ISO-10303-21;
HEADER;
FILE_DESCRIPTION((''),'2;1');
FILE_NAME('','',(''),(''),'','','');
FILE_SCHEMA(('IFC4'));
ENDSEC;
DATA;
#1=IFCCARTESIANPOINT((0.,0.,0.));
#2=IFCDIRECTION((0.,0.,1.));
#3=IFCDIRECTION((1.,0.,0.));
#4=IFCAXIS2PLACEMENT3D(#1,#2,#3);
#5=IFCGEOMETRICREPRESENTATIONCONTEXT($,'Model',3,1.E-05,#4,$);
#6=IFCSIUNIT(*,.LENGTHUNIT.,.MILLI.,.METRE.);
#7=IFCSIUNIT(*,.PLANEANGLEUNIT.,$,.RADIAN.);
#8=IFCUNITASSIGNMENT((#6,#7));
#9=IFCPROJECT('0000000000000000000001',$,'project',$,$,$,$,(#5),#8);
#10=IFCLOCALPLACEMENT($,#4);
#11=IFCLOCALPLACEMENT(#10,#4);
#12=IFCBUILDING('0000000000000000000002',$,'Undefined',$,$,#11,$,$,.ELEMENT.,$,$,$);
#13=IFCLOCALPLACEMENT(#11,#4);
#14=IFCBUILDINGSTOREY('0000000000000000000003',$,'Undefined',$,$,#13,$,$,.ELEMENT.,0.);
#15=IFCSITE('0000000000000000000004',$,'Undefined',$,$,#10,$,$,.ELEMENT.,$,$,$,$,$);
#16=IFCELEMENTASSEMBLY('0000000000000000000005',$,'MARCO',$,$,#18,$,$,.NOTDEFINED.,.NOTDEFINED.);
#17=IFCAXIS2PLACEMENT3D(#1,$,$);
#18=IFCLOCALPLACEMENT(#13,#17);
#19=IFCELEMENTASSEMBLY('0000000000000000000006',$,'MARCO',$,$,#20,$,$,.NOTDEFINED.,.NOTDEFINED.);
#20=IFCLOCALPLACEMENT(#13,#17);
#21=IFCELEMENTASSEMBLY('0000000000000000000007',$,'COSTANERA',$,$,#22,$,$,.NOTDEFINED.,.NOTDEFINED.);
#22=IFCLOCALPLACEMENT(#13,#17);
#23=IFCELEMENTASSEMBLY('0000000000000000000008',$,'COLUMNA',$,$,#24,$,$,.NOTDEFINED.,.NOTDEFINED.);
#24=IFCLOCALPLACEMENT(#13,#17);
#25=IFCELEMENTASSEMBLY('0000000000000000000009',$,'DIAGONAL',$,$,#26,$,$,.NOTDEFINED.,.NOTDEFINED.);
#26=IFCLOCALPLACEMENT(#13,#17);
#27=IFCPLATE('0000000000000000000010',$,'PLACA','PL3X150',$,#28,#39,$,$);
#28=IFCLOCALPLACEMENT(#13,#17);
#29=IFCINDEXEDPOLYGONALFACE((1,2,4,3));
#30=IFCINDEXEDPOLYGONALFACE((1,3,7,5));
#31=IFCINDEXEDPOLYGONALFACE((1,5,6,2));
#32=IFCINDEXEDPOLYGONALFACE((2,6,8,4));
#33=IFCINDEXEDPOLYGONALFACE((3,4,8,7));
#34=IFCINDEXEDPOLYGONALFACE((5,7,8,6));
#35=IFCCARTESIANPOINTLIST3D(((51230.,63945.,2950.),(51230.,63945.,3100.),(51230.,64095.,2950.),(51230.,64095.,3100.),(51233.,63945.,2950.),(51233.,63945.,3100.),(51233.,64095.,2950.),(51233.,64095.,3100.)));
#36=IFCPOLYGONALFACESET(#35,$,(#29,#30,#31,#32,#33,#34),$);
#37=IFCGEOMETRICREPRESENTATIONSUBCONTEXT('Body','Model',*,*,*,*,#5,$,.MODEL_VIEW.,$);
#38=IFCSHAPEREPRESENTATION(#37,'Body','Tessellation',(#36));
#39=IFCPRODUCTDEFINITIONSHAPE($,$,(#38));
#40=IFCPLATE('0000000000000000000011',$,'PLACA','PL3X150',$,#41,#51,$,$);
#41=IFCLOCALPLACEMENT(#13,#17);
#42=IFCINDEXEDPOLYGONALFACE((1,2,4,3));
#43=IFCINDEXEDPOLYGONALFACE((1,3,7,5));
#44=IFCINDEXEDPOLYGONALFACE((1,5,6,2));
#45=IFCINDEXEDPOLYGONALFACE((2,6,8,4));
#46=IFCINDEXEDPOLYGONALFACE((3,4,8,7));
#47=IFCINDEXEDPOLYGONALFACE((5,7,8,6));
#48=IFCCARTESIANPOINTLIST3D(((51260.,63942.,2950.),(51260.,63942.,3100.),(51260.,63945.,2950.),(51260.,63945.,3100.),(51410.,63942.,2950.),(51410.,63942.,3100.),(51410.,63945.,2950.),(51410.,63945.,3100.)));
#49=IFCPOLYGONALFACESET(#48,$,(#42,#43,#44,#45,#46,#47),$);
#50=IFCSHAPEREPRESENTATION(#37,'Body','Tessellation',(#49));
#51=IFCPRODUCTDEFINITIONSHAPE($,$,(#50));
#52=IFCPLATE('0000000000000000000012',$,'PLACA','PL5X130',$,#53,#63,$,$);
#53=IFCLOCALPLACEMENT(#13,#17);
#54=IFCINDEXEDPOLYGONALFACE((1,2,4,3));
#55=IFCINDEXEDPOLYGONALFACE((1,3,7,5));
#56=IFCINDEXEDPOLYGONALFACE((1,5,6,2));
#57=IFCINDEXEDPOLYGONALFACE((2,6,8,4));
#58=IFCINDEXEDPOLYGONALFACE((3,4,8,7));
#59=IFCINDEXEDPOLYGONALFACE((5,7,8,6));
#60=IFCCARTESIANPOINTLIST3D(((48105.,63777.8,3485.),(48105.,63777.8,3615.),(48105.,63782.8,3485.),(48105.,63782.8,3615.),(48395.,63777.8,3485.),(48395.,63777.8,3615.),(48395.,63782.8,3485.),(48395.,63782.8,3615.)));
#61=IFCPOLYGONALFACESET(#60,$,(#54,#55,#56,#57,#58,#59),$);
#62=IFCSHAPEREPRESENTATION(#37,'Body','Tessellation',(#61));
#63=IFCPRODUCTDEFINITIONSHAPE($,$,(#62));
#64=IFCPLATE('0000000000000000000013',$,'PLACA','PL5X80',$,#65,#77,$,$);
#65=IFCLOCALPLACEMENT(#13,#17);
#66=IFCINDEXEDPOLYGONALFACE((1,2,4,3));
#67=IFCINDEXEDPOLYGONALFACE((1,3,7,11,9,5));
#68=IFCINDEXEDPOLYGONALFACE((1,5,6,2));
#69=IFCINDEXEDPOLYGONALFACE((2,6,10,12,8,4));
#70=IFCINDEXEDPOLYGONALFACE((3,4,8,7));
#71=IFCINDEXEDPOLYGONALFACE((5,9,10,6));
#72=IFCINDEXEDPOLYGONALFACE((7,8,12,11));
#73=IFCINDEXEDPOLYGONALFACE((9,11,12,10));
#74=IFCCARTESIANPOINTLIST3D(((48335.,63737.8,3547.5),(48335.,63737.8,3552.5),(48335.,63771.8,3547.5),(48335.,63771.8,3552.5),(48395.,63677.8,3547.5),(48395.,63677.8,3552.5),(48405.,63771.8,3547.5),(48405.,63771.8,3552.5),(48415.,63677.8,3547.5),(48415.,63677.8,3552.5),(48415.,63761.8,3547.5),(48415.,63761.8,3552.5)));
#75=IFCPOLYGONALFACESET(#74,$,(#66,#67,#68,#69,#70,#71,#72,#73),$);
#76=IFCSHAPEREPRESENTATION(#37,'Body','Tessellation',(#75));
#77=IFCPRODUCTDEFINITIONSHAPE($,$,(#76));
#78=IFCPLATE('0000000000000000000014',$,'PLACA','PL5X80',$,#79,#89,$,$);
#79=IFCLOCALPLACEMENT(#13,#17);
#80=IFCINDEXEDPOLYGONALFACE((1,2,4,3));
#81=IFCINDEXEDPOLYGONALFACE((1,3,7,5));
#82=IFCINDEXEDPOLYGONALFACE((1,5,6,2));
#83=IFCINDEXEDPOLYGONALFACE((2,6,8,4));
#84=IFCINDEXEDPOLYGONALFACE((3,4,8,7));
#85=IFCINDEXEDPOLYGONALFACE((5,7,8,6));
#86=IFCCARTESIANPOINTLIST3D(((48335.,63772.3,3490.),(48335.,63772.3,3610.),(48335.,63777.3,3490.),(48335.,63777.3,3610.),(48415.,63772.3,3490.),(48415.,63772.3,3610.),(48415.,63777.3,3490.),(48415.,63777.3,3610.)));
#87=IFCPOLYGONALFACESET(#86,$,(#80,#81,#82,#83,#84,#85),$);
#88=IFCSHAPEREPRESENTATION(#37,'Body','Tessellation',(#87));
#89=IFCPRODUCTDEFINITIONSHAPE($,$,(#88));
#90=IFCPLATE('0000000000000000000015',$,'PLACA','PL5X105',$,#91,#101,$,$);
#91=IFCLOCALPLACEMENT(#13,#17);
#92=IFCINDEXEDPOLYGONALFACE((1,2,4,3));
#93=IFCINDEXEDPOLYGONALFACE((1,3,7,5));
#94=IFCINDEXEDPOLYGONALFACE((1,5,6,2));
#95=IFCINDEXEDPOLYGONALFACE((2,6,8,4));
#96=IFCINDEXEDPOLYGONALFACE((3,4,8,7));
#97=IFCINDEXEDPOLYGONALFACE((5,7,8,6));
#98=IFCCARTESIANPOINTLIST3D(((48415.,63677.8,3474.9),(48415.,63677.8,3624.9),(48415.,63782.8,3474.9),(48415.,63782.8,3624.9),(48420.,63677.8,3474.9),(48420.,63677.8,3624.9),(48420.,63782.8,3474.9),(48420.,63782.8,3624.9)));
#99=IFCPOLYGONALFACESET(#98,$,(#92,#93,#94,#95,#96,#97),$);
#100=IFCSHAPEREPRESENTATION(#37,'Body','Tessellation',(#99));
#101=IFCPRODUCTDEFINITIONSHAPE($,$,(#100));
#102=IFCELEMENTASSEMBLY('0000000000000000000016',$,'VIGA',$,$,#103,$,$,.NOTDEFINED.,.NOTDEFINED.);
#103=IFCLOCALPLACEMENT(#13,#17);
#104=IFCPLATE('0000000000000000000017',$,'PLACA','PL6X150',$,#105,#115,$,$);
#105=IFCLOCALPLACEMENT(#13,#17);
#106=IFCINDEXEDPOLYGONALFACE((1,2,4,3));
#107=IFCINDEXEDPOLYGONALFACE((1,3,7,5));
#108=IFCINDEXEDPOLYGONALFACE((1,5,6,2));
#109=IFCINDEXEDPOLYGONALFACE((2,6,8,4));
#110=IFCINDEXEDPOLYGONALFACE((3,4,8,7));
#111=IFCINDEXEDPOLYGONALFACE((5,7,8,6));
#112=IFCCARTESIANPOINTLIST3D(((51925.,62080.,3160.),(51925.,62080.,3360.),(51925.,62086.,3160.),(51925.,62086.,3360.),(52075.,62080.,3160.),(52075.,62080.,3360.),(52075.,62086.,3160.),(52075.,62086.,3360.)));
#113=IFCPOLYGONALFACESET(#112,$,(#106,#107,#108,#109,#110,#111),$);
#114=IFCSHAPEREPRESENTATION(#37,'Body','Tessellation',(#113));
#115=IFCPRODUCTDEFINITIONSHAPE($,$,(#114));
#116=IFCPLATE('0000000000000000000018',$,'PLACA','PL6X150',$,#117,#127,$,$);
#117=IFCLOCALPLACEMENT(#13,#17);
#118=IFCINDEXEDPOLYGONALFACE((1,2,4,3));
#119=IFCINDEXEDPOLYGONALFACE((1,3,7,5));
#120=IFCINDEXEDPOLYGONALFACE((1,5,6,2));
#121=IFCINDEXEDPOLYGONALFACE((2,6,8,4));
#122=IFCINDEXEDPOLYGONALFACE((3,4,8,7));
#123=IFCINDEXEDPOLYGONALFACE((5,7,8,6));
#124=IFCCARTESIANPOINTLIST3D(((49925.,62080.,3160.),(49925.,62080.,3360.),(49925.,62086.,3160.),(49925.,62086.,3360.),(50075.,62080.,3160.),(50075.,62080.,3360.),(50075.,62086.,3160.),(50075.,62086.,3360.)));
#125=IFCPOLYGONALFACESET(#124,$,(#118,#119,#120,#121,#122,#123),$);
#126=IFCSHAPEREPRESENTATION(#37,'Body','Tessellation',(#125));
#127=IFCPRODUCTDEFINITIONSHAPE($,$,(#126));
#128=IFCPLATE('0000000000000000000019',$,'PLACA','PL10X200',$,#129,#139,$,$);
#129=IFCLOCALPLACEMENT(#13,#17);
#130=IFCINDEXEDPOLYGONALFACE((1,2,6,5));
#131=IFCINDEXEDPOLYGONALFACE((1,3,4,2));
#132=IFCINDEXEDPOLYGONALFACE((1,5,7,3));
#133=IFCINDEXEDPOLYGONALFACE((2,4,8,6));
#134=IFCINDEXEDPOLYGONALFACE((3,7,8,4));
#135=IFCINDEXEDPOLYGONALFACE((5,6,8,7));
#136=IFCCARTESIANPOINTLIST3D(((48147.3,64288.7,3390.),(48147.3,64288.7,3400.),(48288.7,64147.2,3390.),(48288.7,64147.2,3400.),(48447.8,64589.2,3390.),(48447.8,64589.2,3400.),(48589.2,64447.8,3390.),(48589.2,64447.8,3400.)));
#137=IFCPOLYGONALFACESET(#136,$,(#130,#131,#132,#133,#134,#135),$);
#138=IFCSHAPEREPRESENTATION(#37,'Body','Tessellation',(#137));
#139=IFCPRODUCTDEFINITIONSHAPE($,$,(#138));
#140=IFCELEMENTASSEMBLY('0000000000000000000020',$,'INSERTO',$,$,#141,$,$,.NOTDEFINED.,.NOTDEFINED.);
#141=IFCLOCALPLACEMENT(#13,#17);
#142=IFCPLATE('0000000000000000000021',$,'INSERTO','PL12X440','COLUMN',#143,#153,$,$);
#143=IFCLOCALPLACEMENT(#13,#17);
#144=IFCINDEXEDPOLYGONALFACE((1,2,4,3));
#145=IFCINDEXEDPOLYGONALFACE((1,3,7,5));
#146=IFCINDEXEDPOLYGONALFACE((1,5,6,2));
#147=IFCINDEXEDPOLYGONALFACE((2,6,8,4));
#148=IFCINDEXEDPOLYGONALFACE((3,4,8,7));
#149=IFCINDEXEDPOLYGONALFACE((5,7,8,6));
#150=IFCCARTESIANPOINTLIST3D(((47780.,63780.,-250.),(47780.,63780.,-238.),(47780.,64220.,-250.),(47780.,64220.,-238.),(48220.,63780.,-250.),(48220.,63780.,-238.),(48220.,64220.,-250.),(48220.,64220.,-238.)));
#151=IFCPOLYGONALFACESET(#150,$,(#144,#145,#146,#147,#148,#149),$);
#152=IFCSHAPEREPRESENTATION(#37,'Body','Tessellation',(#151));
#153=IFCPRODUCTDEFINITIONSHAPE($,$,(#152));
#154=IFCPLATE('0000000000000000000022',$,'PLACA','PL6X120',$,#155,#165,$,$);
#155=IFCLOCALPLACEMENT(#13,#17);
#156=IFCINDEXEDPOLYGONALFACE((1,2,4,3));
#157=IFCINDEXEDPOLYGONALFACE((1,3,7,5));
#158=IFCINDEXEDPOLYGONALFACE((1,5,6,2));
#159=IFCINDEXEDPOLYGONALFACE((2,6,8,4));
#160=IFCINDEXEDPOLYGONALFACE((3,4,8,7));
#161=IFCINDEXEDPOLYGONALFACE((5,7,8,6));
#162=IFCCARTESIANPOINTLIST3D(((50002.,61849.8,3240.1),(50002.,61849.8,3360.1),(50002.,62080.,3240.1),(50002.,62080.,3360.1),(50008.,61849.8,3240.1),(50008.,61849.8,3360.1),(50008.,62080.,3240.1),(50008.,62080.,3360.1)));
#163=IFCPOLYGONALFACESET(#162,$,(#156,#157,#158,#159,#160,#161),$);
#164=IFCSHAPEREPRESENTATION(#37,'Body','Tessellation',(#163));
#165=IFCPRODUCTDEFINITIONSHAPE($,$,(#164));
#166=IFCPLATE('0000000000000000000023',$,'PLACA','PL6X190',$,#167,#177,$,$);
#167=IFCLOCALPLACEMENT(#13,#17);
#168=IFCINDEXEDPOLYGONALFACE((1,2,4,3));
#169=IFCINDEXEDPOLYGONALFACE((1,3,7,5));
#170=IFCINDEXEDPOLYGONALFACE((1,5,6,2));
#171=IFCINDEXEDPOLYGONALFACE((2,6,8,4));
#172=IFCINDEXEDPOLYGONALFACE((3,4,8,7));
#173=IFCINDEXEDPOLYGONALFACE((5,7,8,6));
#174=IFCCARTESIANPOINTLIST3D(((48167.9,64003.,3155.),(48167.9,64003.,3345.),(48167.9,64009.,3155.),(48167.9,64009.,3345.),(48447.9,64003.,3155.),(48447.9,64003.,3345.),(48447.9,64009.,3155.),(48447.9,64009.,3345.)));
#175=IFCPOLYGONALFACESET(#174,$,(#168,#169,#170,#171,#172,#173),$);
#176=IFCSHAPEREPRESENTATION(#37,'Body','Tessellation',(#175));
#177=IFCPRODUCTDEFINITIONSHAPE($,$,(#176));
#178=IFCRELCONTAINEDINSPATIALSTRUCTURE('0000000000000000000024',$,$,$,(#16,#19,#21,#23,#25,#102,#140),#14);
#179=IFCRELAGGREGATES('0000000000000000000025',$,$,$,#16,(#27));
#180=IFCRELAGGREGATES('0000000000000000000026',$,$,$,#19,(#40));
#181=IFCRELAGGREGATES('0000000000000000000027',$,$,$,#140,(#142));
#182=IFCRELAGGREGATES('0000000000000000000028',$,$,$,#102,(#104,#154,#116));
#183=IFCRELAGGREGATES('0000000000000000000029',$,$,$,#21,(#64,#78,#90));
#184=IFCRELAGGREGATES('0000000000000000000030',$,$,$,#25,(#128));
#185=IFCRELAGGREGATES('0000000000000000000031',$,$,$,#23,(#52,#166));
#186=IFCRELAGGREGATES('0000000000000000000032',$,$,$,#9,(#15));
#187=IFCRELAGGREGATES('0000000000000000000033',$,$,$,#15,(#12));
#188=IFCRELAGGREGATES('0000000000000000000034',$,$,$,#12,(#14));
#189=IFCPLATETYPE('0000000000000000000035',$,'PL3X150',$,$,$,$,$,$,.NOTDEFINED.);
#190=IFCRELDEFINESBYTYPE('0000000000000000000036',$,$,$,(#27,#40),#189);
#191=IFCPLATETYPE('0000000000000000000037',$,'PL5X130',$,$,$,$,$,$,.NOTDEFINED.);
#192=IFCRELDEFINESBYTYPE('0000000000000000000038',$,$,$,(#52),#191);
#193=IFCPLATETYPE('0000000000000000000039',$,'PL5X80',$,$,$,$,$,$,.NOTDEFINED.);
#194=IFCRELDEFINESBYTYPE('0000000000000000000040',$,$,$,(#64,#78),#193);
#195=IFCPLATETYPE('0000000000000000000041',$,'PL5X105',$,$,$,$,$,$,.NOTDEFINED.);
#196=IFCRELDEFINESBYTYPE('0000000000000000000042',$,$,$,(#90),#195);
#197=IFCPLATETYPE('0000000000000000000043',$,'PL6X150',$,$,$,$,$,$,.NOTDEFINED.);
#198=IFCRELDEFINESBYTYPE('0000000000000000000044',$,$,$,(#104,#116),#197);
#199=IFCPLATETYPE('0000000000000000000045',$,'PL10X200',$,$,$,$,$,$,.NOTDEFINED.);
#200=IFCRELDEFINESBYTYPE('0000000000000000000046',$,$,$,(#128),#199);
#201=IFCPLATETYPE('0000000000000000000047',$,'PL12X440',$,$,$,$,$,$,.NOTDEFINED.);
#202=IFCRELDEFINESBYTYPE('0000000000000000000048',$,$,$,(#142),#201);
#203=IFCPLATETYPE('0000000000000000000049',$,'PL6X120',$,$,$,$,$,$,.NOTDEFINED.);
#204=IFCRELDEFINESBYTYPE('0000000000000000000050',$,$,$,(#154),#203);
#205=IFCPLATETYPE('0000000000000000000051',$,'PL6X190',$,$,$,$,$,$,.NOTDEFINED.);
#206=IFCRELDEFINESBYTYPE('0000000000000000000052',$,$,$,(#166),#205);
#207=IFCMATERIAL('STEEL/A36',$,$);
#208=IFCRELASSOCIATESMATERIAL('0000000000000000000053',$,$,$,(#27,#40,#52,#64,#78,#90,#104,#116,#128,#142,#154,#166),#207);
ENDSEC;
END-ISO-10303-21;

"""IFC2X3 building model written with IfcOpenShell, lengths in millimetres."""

from ifc_helpers import new_model, si_unit, frame, origin_with_axes, place, context, subcontext, project, spatial, polyline, outline, extrude, material, type_object, element, aggregate, save


model = new_model("IFC2X3")

# Units and contexts
model_context = context("Model", 3, precision=1e-05, world=origin_with_axes())
body_context = subcontext(model_context, "Body", "Model", "MODEL_VIEW")
ifc_project = project(units=[si_unit("LENGTHUNIT", "METRE", prefix="MILLI"), si_unit("PLANEANGLEUNIT", "RADIAN")], contexts=[model_context])

# Site, building, storey
site_placement = place(None, origin_with_axes())
site = spatial("IfcSite", under=ifc_project, at=site_placement, Name="Undefined", CompositionType="ELEMENT")
building_placement = place(site_placement, origin_with_axes())
building = spatial("IfcBuilding", under=site, at=building_placement, Name="Undefined", CompositionType="ELEMENT")
storey_placement = place(building_placement, origin_with_axes())
storey = spatial("IfcBuildingStorey", under=building, at=storey_placement, Name="Undefined", CompositionType="ELEMENT", Elevation=0.0)

# Element assembly
assembly_1_placement = place(storey_placement, origin_with_axes())
assembly_1 = element("IfcElementAssembly", 1, at=assembly_1_placement, inside=storey, Name="MARCO", AssemblyPlace="NOTDEFINED", PredefinedType="NOTDEFINED")
ifc_material_1 = material(Name="STEEL/A36")

# Element assemblies
assembly_2_placement = place(storey_placement, origin_with_axes())
assembly_2 = element("IfcElementAssembly", 2, at=assembly_2_placement, inside=storey, Name="MARCO", AssemblyPlace="NOTDEFINED", PredefinedType="NOTDEFINED")
assembly_3_placement = place(storey_placement, origin_with_axes())
assembly_3 = element("IfcElementAssembly", 3, at=assembly_3_placement, inside=storey, Name="COSTANERA", AssemblyPlace="NOTDEFINED", PredefinedType="NOTDEFINED")
assembly_4_placement = place(storey_placement, origin_with_axes())
assembly_4 = element("IfcElementAssembly", 4, at=assembly_4_placement, inside=storey, Name="COLUMNA", AssemblyPlace="NOTDEFINED", PredefinedType="NOTDEFINED")

# Element assembly
assembly_5_placement = place(storey_placement, origin_with_axes())
assembly_5 = element("IfcElementAssembly", 5, at=assembly_5_placement, inside=storey, Name="DIAGONAL", AssemblyPlace="NOTDEFINED", PredefinedType="NOTDEFINED")

# Plates
plate_type_1 = type_object("IfcPlateType", Name="PL3X150", PredefinedType="NOTDEFINED")
plate_1_placement = place(assembly_1_placement, frame((51231.5, 64095.0, 2950.0), z_axis=(-1.0, 0.0, 0.0), x_axis=(0.0, -1.0, 0.0)))
plate_1 = element("IfcPlate", 6, at=plate_1_placement, type_object=plate_type_1, material=ifc_material_1, Name="PLACA", Description="PL3X150", context=body_context, shape_type="SweptSolid", body=[
    extrude(outline(polyline([(0.0, 0.0), (150.0, 0.0), (150.0, 150.0), (0.0, 150.0), (0.0, 0.0)])), frame((0.0, 0.0, -1.5), z_axis=(0.0, 0.0, 1.0), x_axis=(1.0, 0.0, 0.0)), (0.0, 0.0, 1.0), 3.0),
])
aggregate(assembly_1, [plate_1])
plate_2_placement = place(assembly_2_placement, frame((51410.0, 63943.5, 2950.0), z_axis=(0.0, 1.0, 0.0), x_axis=(-1.0, 0.0, 0.0)))
plate_2 = element("IfcPlate", 7, at=plate_2_placement, type_object=plate_type_1, material=ifc_material_1, Name="PLACA", Description="PL3X150", context=body_context, shape_type="SweptSolid", body=[
    extrude(outline(polyline([(0.0, 0.0), (150.0, 0.0), (150.0, 150.0), (0.0, 150.0), (0.0, 0.0)])), frame((0.0, 0.0, -1.5), z_axis=(0.0, 0.0, 1.0), x_axis=(1.0, 0.0, 0.0)), (0.0, 0.0, 1.0), 3.0),
])
aggregate(assembly_2, [plate_2])
plate_type_2 = type_object("IfcPlateType", Name="PL5X130", PredefinedType="NOTDEFINED")
plate_3_placement = place(assembly_4_placement, frame((48395.0, 63780.3, 3615.0), z_axis=(0.0, -1.0, 0.0), x_axis=(-1.0, 0.0, 0.0)))
plate_3 = element("IfcPlate", 8, at=plate_3_placement, type_object=plate_type_2, material=ifc_material_1, Name="PLACA", Description="PL5X130", context=body_context, shape_type="SweptSolid", body=[
    extrude(outline(polyline([(0.0, 0.0), (290.0, 0.0), (290.0, 130.0), (0.0, 130.0), (0.0, 0.0)])), frame((0.0, 0.0, -2.5), z_axis=(0.0, 0.0, 1.0), x_axis=(1.0, 0.0, 0.0)), (0.0, 0.0, 1.0), 5.0),
])
plate_type_3 = type_object("IfcPlateType", Name="PL5X80", PredefinedType="NOTDEFINED")
plate_4_placement = place(assembly_3_placement, frame((48335.0, 63771.8, 3550.0), z_axis=(0.0, 0.0, -1.0), x_axis=(1.0, 0.0, 0.0)))
plate_4 = element("IfcPlate", 9, at=plate_4_placement, type_object=plate_type_3, material=ifc_material_1, Name="PLACA", Description="PL5X80", context=body_context, shape_type="SweptSolid", body=[
    extrude(outline(polyline([(0.0, 0.0), (70.0, 0.0), (80.0, 10.0), (80.0, 94.0), (60.0, 94.0), (0.0, 34.0), (0.0, 0.0)])), frame((0.0, 0.0, -2.5), z_axis=(0.0, 0.0, 1.0), x_axis=(1.0, 0.0, 0.0)), (0.0, 0.0, 1.0), 5.0),
])
plate_5_placement = place(assembly_3_placement, frame((48335.0, 63774.8, 3610.0), z_axis=(0.0, 1.0, 0.0), x_axis=(1.0, 0.0, 0.0)))
plate_5 = element("IfcPlate", 10, at=plate_5_placement, type_object=plate_type_3, material=ifc_material_1, Name="PLACA", Description="PL5X80", context=body_context, shape_type="SweptSolid", body=[
    extrude(outline(polyline([(0.0, 0.0), (80.0, 0.0), (80.0, 120.0), (0.0, 120.0), (0.0, 0.0)])), frame((0.0, 0.0, -2.5), z_axis=(0.0, 0.0, 1.0), x_axis=(1.0, 0.0, 0.0)), (0.0, 0.0, 1.0), 5.0),
])
plate_type_4 = type_object("IfcPlateType", Name="PL5X105", PredefinedType="NOTDEFINED")
plate_6_placement = place(assembly_3_placement, frame((48417.5, 63677.8, 3474.9), z_axis=(1.0, 0.0, 0.0), x_axis=(0.0, 1.0, 0.0)))
plate_6 = element("IfcPlate", 11, at=plate_6_placement, type_object=plate_type_4, material=ifc_material_1, Name="PLACA", Description="PL5X105", context=body_context, shape_type="SweptSolid", body=[
    extrude(outline(polyline([(0.0, 0.0), (105.0, 0.0), (105.0, 150.0), (0.0, 150.0), (0.0, 0.0)])), frame((0.0, 0.0, -2.5), z_axis=(0.0, 0.0, 1.0), x_axis=(1.0, 0.0, 0.0)), (0.0, 0.0, 1.0), 5.0),
])

# Element assembly, plates
assembly_6_placement = place(storey_placement, origin_with_axes())
assembly_6 = element("IfcElementAssembly", 12, at=assembly_6_placement, inside=storey, Name="VIGA", AssemblyPlace="NOTDEFINED", PredefinedType="NOTDEFINED")
plate_type_5 = type_object("IfcPlateType", Name="PL6X150", PredefinedType="NOTDEFINED")
plate_7_placement = place(assembly_6_placement, frame((51925.0, 62083.0, 3360.0), z_axis=(0.0, 1.0, 0.0), x_axis=(1.0, 0.0, 0.0)))
plate_7 = element("IfcPlate", 13, at=plate_7_placement, type_object=plate_type_5, material=ifc_material_1, Name="PLACA", Description="PL6X150", context=body_context, shape_type="SweptSolid", body=[
    extrude(outline(polyline([(0.0, 0.0), (150.0, 0.0), (150.0, 200.0), (0.0, 200.0), (0.0, 0.0)])), frame((0.0, 0.0, -3.0), z_axis=(0.0, 0.0, 1.0), x_axis=(1.0, 0.0, 0.0)), (0.0, 0.0, 1.0), 6.0),
])
plate_8_placement = place(assembly_6_placement, frame((49925.0, 62083.0, 3360.0), z_axis=(0.0, 1.0, 0.0), x_axis=(1.0, 0.0, 0.0)))
plate_8 = element("IfcPlate", 14, at=plate_8_placement, type_object=plate_type_5, material=ifc_material_1, Name="PLACA", Description="PL6X150", context=body_context, shape_type="SweptSolid", body=[
    extrude(outline(polyline([(0.0, 0.0), (150.0, 0.0), (150.0, 200.0), (0.0, 200.0), (0.0, 0.0)])), frame((0.0, 0.0, -3.0), z_axis=(0.0, 0.0, 1.0), x_axis=(1.0, 0.0, 0.0)), (0.0, 0.0, 1.0), 6.0),
])

# Plate
plate_type_6 = type_object("IfcPlateType", Name="PL10X200", PredefinedType="NOTDEFINED")
plate_9_placement = place(assembly_5_placement, frame((48218.0, 64218.0, 3395.0), z_axis=(0.0, 0.0, -1.0), x_axis=(0.707107, 0.707107, 0.0)))
plate_9 = element("IfcPlate", 15, at=plate_9_placement, type_object=plate_type_6, material=ifc_material_1, Name="PLACA", Description="PL10X200", context=body_context, shape_type="SweptSolid", body=[
    extrude(outline(polyline([(0.0, -100.0), (0.0, 100.0), (425.0, 100.0), (425.0, -100.0), (0.0, -100.0)])), frame((0.0, 0.0, -5.0), z_axis=(0.0, 0.0, 1.0), x_axis=(1.0, 0.0, 0.0)), (0.0, 0.0, 1.0), 10.0),
])

# Element assembly, plate
assembly_7_placement = place(storey_placement, origin_with_axes())
assembly_7 = element("IfcElementAssembly", 16, at=assembly_7_placement, inside=storey, Name="INSERTO", AssemblyPlace="NOTDEFINED", PredefinedType="NOTDEFINED")
plate_type_7 = type_object("IfcPlateType", Name="PL12X440", PredefinedType="NOTDEFINED")
plate_10_placement = place(assembly_7_placement, frame((48220.0, 64000.0, -244.0), z_axis=(0.0, 0.0, 1.0), x_axis=(-1.0, 0.0, 0.0)))
plate_10 = element("IfcPlate", 17, at=plate_10_placement, type_object=plate_type_7, material=ifc_material_1, Name="INSERTO", Description="PL12X440", ObjectType="COLUMN", context=body_context, shape_type="SweptSolid", body=[
    extrude(outline(polyline([(0.0, -220.0), (0.0, 220.0), (440.0, 220.0), (440.0, -220.0), (0.0, -220.0)])), frame((0.0, 0.0, -6.0), z_axis=(0.0, 0.0, 1.0), x_axis=(1.0, 0.0, 0.0)), (0.0, 0.0, 1.0), 12.0),
])
aggregate(assembly_7, [plate_10])

# Plates
plate_type_8 = type_object("IfcPlateType", Name="PL6X120", PredefinedType="NOTDEFINED")
plate_11_placement = place(assembly_6_placement, frame((50005.0, 62080.0, 3360.1), z_axis=(-1.0, 0.0, 0.0), x_axis=(0.0, 0.0, -1.0)))
plate_11 = element("IfcPlate", 18, at=plate_11_placement, type_object=plate_type_8, material=ifc_material_1, Name="PLACA", Description="PL6X120", context=body_context, shape_type="SweptSolid", body=[
    extrude(outline(polyline([(0.0, 0.0), (120.0, 0.0), (120.0, 230.2), (0.0, 230.2), (0.0, 0.0)])), frame((0.0, 0.0, -3.0), z_axis=(0.0, 0.0, 1.0), x_axis=(1.0, 0.0, 0.0)), (0.0, 0.0, 1.0), 6.0),
])
aggregate(assembly_6, [plate_7, plate_11, plate_8])
plate_type_9 = type_object("IfcPlateType", Name="PL6X190", PredefinedType="NOTDEFINED")
plate_12_placement = place(assembly_4_placement, frame((48447.9, 64006.0, 3250.0), z_axis=(0.0, 1.0, 0.0), x_axis=(-1.0, 0.0, 0.0)))
plate_12 = element("IfcPlate", 19, at=plate_12_placement, type_object=plate_type_9, material=ifc_material_1, Name="PLACA", Description="PL6X190", context=body_context, shape_type="SweptSolid", body=[
    extrude(outline(polyline([(0.0, -95.0), (0.0, 95.0), (280.0, 95.0), (280.0, -95.0), (0.0, -95.0)])), frame((0.0, 0.0, -3.0), z_axis=(0.0, 0.0, 1.0), x_axis=(1.0, 0.0, 0.0)), (0.0, 0.0, 1.0), 6.0),
])

aggregate(assembly_3, [plate_4, plate_5, plate_6])
aggregate(assembly_5, [plate_9])
aggregate(assembly_4, [plate_3, plate_12])

save(model, "model.ifc")
